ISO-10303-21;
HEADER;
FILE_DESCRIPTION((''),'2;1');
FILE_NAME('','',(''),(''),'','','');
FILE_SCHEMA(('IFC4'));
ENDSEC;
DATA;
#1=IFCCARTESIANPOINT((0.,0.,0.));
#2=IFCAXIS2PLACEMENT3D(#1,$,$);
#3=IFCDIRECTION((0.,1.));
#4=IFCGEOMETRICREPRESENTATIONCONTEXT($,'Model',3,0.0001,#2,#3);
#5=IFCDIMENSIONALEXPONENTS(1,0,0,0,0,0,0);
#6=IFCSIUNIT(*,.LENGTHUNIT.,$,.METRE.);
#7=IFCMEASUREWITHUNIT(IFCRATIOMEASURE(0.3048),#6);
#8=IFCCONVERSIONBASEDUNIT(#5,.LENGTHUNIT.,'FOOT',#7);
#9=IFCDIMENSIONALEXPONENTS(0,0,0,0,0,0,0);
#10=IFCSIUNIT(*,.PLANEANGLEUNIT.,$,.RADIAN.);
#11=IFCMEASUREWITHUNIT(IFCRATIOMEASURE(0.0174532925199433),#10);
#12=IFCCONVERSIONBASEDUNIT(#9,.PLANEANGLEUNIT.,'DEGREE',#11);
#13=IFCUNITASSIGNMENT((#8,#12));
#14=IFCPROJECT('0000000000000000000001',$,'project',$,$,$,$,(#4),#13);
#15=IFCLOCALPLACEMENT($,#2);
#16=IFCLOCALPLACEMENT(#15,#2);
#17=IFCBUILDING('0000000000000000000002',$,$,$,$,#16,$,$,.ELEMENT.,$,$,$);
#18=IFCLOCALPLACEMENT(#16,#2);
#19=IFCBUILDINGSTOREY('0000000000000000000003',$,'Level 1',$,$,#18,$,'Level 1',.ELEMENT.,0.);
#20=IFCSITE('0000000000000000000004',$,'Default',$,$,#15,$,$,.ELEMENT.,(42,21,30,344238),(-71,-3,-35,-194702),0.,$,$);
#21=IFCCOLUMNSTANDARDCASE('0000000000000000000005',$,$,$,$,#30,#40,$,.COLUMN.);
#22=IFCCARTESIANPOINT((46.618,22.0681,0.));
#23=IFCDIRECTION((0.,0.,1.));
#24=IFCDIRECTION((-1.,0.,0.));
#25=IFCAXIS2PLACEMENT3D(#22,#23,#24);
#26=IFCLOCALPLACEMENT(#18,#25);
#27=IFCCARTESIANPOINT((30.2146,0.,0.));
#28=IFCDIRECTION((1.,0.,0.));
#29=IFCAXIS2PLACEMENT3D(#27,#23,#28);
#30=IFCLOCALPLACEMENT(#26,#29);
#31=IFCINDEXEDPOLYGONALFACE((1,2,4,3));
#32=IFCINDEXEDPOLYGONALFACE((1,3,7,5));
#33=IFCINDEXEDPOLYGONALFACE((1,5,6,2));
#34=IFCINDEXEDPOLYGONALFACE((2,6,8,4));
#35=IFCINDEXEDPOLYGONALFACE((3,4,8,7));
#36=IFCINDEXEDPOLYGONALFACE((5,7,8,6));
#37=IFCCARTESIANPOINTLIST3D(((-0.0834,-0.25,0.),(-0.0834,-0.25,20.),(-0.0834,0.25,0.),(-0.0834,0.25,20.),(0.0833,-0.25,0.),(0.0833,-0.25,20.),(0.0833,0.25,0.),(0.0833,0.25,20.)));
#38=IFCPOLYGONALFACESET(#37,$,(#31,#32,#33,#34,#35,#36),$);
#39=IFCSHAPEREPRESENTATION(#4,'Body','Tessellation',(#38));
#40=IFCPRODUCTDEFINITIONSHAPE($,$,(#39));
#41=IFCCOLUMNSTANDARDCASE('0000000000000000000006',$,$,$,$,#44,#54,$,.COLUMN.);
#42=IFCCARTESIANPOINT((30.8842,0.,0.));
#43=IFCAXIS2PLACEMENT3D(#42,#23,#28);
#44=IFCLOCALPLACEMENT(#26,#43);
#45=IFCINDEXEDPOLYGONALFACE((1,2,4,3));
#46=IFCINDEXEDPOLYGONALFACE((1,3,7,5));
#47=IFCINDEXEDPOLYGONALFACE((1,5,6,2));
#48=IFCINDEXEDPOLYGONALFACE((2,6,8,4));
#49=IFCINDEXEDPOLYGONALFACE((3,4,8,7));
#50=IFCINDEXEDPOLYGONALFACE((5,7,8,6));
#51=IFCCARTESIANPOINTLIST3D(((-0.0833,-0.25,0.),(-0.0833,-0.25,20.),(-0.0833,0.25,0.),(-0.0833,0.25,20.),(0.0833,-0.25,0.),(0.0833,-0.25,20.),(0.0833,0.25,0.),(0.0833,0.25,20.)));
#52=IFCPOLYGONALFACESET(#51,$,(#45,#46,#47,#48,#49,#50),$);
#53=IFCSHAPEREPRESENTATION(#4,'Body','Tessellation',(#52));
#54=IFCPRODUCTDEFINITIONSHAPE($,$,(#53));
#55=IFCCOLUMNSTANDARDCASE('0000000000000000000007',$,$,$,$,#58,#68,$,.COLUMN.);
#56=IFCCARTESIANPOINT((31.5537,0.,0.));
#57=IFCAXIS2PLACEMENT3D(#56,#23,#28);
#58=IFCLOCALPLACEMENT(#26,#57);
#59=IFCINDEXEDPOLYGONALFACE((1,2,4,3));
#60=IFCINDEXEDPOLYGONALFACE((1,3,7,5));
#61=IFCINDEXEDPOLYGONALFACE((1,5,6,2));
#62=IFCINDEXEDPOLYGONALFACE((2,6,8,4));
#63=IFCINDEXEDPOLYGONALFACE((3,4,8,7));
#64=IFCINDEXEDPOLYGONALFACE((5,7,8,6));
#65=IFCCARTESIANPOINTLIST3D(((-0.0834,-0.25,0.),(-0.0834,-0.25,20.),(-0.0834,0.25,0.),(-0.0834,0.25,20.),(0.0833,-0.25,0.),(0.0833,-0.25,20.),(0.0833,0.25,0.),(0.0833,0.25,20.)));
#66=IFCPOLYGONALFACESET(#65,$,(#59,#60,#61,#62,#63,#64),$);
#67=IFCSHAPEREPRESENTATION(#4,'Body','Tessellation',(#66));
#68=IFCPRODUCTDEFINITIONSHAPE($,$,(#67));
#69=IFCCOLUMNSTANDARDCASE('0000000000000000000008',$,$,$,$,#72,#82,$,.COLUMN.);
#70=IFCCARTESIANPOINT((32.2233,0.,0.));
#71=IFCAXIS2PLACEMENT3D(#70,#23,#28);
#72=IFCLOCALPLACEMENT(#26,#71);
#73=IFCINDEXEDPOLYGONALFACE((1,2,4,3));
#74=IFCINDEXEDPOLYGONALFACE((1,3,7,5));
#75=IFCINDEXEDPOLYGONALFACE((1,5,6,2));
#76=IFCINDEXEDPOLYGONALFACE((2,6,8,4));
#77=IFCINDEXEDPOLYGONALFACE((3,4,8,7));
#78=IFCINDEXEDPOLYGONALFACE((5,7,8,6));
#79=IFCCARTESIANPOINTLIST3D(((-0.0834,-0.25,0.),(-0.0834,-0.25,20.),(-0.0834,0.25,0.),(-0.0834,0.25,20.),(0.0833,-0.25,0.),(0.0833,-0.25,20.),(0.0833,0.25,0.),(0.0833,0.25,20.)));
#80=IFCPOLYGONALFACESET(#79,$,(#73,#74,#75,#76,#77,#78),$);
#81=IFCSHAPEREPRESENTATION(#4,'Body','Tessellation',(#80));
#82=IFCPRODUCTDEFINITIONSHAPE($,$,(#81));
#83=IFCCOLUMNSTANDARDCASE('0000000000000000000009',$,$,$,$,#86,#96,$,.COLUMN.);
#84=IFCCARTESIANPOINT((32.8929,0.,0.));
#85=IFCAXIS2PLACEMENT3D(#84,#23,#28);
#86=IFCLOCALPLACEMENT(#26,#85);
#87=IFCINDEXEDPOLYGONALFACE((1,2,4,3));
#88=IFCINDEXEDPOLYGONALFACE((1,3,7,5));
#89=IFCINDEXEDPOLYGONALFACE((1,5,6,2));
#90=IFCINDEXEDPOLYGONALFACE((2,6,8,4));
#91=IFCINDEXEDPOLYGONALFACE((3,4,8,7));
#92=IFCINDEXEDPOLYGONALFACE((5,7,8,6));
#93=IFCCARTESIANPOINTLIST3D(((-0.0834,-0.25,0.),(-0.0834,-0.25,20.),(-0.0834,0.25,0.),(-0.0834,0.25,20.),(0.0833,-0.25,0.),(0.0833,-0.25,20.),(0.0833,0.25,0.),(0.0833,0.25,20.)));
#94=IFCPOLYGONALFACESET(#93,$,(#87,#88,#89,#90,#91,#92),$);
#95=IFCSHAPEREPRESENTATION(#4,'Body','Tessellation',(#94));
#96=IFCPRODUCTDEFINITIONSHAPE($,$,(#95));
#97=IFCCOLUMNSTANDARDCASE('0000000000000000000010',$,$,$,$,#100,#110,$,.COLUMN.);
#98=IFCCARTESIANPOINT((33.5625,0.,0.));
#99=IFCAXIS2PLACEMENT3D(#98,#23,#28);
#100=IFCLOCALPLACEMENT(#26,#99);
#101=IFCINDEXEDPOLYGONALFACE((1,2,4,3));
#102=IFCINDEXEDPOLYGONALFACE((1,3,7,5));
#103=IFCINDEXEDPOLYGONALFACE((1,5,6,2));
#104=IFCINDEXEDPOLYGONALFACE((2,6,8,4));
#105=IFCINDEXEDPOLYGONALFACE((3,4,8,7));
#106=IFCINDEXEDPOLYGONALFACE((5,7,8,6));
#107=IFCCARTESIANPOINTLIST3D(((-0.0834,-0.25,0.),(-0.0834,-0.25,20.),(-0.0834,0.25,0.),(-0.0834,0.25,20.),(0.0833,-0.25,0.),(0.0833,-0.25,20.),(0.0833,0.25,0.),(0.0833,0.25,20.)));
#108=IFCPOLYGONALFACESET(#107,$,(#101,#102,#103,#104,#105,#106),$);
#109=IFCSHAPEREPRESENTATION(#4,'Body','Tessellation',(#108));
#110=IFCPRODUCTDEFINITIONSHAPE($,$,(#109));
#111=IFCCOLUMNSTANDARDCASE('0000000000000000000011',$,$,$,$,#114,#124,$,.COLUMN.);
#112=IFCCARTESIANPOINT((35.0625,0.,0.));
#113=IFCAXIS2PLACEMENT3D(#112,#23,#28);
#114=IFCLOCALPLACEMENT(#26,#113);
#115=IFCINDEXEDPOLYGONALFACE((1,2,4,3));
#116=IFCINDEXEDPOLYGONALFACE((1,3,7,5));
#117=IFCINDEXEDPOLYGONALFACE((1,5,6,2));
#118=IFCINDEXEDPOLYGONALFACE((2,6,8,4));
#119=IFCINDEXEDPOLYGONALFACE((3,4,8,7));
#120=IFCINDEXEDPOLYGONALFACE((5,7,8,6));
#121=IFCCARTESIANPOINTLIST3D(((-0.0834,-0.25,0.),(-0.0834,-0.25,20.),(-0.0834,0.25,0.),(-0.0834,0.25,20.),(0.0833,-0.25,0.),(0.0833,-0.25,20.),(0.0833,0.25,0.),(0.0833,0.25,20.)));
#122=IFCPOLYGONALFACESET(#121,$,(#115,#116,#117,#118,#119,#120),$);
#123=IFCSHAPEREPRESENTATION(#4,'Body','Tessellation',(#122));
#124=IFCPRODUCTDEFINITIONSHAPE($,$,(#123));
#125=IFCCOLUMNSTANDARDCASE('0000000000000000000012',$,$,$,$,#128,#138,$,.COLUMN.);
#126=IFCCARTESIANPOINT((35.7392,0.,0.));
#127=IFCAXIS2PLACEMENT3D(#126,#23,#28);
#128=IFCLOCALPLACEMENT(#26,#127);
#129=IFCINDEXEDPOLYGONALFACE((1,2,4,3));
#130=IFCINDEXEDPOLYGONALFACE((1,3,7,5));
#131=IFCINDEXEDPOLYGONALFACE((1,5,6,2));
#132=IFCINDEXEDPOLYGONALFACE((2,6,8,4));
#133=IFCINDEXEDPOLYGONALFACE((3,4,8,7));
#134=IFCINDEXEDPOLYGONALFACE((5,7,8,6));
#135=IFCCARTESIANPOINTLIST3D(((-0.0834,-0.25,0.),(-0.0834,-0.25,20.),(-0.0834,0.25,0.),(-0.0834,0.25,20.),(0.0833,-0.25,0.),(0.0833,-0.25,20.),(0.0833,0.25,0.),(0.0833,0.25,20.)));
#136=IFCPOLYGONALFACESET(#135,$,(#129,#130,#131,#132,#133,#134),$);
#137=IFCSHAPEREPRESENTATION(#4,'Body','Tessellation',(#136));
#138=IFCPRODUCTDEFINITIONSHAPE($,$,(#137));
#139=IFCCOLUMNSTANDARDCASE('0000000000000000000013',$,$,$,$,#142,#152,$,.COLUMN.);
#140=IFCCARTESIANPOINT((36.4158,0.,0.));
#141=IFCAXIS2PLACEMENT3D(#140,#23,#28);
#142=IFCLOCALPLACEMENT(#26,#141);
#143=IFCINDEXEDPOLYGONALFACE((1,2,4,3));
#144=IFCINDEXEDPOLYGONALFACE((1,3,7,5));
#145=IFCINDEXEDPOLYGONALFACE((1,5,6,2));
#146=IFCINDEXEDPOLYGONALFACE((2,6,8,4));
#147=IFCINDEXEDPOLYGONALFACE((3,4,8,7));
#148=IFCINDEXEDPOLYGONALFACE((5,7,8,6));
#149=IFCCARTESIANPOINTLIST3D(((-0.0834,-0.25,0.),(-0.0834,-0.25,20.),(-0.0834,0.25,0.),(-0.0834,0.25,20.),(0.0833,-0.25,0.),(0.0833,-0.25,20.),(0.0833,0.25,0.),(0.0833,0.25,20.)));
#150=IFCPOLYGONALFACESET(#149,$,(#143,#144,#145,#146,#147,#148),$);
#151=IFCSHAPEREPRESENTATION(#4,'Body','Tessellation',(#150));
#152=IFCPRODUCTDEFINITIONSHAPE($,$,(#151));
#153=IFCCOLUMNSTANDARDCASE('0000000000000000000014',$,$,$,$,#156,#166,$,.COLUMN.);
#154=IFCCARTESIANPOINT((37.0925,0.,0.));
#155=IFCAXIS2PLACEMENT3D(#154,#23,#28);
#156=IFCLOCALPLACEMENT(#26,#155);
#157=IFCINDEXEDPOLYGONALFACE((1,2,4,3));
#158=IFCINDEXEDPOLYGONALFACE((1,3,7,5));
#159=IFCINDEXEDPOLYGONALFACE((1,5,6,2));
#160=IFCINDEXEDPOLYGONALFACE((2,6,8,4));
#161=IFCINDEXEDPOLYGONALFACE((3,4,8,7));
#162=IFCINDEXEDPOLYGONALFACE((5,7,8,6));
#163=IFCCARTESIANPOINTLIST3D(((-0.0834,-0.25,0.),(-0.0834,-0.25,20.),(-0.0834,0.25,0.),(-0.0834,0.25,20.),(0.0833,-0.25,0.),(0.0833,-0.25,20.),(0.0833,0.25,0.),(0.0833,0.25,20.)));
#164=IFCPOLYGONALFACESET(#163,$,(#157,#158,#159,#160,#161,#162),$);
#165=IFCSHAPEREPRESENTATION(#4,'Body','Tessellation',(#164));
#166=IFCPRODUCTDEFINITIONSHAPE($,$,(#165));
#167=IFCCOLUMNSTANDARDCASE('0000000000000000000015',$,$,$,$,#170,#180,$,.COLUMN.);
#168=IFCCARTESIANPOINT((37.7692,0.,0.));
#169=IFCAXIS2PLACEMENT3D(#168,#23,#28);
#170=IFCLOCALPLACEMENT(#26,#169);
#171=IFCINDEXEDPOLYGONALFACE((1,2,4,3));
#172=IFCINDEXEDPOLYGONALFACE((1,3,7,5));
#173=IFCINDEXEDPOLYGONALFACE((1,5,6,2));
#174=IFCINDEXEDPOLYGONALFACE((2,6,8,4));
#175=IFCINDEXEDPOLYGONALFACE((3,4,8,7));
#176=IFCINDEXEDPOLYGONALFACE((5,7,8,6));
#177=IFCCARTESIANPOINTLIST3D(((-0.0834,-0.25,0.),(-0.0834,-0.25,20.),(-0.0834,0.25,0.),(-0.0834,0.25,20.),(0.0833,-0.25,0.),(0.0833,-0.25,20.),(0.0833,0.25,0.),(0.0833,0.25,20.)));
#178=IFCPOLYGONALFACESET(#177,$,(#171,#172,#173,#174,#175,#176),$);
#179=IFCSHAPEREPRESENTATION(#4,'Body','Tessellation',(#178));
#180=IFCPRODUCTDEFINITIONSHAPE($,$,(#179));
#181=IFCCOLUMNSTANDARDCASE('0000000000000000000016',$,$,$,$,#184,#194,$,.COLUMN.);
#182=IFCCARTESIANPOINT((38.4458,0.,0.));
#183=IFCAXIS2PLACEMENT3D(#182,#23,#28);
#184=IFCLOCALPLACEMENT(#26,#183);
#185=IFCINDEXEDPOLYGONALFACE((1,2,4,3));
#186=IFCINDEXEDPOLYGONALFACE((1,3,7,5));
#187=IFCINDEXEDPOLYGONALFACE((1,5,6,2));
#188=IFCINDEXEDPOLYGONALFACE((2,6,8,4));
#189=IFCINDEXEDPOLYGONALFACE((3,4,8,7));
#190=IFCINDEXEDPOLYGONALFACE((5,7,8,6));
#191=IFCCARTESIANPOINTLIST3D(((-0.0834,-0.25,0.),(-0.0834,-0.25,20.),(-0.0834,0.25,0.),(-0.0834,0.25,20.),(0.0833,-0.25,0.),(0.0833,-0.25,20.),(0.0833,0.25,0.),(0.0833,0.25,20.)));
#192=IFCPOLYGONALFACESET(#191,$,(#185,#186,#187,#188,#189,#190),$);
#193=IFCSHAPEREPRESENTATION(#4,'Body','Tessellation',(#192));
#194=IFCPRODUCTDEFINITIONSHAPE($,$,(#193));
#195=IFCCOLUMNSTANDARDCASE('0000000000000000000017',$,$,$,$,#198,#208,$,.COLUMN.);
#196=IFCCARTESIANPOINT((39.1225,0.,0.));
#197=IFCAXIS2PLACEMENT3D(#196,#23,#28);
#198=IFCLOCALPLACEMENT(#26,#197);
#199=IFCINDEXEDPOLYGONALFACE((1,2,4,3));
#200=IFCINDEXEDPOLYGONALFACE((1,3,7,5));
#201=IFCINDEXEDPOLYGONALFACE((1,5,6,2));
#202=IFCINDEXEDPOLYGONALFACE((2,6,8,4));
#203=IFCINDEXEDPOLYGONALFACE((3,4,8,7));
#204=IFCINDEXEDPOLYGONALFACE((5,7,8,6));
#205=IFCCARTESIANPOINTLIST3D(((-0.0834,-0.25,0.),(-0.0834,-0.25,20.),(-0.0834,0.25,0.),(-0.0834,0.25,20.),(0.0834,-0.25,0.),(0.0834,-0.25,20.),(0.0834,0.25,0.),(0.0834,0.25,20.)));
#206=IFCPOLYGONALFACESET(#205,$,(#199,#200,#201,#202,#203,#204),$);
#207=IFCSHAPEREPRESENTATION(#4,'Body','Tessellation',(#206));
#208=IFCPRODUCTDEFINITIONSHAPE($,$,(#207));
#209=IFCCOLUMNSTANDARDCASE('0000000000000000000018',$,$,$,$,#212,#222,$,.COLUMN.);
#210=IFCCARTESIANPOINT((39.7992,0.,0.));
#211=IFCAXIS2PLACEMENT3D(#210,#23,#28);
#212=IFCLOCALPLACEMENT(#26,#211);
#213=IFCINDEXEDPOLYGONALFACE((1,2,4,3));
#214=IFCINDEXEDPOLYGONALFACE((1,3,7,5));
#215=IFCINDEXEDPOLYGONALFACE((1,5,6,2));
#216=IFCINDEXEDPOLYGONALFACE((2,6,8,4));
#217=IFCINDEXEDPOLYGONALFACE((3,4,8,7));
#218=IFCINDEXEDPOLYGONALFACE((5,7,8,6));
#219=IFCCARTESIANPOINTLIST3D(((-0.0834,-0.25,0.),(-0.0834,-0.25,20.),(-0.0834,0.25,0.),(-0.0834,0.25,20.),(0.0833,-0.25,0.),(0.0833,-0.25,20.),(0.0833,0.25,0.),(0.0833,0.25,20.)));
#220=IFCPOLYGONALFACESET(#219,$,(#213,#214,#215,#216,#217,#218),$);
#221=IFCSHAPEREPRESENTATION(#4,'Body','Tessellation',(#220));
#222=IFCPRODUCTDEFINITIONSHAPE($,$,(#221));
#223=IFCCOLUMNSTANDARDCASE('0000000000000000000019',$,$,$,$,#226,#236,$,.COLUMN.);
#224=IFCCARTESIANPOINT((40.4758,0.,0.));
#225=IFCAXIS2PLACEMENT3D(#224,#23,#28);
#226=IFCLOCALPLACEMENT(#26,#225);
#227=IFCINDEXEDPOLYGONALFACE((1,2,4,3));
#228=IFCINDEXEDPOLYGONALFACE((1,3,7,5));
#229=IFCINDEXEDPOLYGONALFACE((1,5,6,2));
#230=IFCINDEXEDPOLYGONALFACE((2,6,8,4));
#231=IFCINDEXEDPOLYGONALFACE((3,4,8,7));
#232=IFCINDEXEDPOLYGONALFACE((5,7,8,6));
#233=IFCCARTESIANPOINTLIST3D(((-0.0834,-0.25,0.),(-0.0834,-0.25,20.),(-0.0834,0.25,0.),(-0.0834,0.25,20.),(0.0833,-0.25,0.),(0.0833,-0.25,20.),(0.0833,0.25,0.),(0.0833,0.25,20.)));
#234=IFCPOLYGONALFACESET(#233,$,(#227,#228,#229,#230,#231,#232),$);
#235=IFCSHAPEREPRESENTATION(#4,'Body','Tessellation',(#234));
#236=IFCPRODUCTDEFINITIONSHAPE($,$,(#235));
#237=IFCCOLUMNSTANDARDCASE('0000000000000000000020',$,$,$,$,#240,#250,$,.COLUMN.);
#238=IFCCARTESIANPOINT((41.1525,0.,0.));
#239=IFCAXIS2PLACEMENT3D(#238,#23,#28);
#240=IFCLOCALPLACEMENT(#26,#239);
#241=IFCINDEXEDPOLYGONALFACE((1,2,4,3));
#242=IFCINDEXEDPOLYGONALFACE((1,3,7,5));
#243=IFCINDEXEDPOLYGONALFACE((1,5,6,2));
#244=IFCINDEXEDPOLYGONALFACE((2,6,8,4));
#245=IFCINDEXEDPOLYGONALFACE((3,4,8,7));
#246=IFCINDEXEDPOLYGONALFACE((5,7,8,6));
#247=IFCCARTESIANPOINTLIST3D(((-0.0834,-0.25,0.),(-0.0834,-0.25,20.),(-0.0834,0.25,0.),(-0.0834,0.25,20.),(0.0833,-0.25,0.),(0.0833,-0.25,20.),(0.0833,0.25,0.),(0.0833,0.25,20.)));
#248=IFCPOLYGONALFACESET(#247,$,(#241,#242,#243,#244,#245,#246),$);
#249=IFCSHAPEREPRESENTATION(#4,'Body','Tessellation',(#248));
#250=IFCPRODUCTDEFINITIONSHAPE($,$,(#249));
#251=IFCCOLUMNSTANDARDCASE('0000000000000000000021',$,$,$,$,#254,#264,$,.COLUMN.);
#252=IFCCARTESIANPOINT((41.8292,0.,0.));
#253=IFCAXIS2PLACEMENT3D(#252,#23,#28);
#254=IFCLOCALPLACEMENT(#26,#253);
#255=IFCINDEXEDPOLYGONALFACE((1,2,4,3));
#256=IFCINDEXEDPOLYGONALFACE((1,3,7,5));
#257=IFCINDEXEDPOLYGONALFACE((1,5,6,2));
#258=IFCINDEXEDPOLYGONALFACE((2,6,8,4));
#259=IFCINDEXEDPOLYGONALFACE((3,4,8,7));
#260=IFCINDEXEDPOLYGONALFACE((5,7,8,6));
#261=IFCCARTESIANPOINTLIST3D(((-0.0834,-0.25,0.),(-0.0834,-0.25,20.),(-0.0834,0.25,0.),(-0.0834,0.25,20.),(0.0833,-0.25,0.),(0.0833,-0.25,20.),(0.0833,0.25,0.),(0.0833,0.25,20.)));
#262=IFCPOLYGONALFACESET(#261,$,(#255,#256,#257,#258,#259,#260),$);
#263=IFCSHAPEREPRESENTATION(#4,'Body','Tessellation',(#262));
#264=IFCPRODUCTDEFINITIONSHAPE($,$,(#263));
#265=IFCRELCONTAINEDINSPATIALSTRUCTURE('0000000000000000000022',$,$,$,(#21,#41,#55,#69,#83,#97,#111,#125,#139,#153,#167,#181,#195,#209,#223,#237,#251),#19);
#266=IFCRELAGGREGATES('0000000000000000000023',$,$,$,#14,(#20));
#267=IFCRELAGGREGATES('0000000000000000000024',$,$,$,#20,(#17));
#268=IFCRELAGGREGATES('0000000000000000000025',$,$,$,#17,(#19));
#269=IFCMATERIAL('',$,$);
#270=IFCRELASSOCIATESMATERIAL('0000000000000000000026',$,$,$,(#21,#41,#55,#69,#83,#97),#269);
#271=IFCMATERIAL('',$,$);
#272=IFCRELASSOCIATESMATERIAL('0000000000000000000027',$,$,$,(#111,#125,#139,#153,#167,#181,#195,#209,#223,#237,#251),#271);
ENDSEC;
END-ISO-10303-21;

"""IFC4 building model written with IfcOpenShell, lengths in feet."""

from ifc_helpers import new_model, entity, si_unit, converted_unit, direction, frame, origin, place, context, project, spatial, rectangle, extrude, material, element, save


model = new_model("IFC4")

# Units and contexts
model_context = context("Model", 3, precision=0.0001, world=origin(), true_north=direction((0.0, 1.0)))
ifc_project = project(units=[converted_unit("LENGTHUNIT", "FOOT", entity("IfcRatioMeasure", 0.3048), si_unit("LENGTHUNIT", "METRE"), dimensions=[1, 0, 0, 0, 0, 0, 0]), converted_unit("PLANEANGLEUNIT", "DEGREE", entity("IfcRatioMeasure", 0.0174532925199433), si_unit("PLANEANGLEUNIT", "RADIAN"), dimensions=[0, 0, 0, 0, 0, 0, 0])], contexts=[model_context])

# Site, building, storey
site_placement = place(None, origin())
site = spatial("IfcSite", under=ifc_project, at=site_placement, Name="Default", CompositionType="ELEMENT", RefLatitude=(42, 21, 30, 344238), RefLongitude=(-71, -3, -35, -194702), RefElevation=0.0)
building_placement = place(site_placement, origin())
building = spatial("IfcBuilding", under=site, at=building_placement, CompositionType="ELEMENT")
storey_placement = place(building_placement, origin())
storey = spatial("IfcBuildingStorey", under=building, at=storey_placement, Name="Level 1", LongName="Level 1", CompositionType="ELEMENT", Elevation=0.0)

# Columns
ifc_material_1 = material(Name="")
placement = place(storey_placement, frame((46.618, 22.0681, 0.0), z_axis=(0.0, 0.0, 1.0), x_axis=(-1.0, 0.0, 0.0)))
for number, where, z_axis, x_axis in (
    (1, (30.2146, 0.0, 0.0), (0.0, 0.0, 1.0), (1.0, 0.0, 0.0)),
    (2, (30.8842, 0.0, 0.0), (0.0, 0.0, 1.0), (1.0, 0.0, 0.0)),
    (3, (31.5537, 0.0, 0.0), (0.0, 0.0, 1.0), (1.0, 0.0, 0.0)),
    (4, (32.2233, 0.0, 0.0), (0.0, 0.0, 1.0), (1.0, 0.0, 0.0)),
    (5, (32.8929, 0.0, 0.0), (0.0, 0.0, 1.0), (1.0, 0.0, 0.0)),
    (6, (33.5625, 0.0, 0.0), (0.0, 0.0, 1.0), (1.0, 0.0, 0.0)),
):
    element("IfcColumnStandardCase", number, at=place(placement, frame(where, z_axis=z_axis, x_axis=x_axis)), inside=storey, material=ifc_material_1, PredefinedType="COLUMN", context=model_context, shape_type="SweptSolid", body=[
        extrude(rectangle(XDim=0.1667, YDim=0.5), origin(), (0.0, 0.0, 1.0), 20.0),
    ])
ifc_material_2 = material(Name="")
for number, where, z_axis, x_axis in (
    (7, (35.0625, 0.0, 0.0), (0.0, 0.0, 1.0), (1.0, 0.0, 0.0)),
    (8, (35.7392, 0.0, 0.0), (0.0, 0.0, 1.0), (1.0, 0.0, 0.0)),
    (9, (36.4158, 0.0, 0.0), (0.0, 0.0, 1.0), (1.0, 0.0, 0.0)),
    (10, (37.0925, 0.0, 0.0), (0.0, 0.0, 1.0), (1.0, 0.0, 0.0)),
    (11, (37.7692, 0.0, 0.0), (0.0, 0.0, 1.0), (1.0, 0.0, 0.0)),
    (12, (38.4458, 0.0, 0.0), (0.0, 0.0, 1.0), (1.0, 0.0, 0.0)),
    (13, (39.1225, 0.0, 0.0), (0.0, 0.0, 1.0), (1.0, 0.0, 0.0)),
    (14, (39.7992, 0.0, 0.0), (0.0, 0.0, 1.0), (1.0, 0.0, 0.0)),
    (15, (40.4758, 0.0, 0.0), (0.0, 0.0, 1.0), (1.0, 0.0, 0.0)),
    (16, (41.1525, 0.0, 0.0), (0.0, 0.0, 1.0), (1.0, 0.0, 0.0)),
    (17, (41.8292, 0.0, 0.0), (0.0, 0.0, 1.0), (1.0, 0.0, 0.0)),
):
    element("IfcColumnStandardCase", number, at=place(placement, frame(where, z_axis=z_axis, x_axis=x_axis)), inside=storey, material=ifc_material_2, PredefinedType="COLUMN", context=model_context, shape_type="SweptSolid", body=[
        extrude(rectangle(XDim=0.1667, YDim=0.5), origin(), (0.0, 0.0, 1.0), 20.0),
    ])

save(model, "model.ifc")
